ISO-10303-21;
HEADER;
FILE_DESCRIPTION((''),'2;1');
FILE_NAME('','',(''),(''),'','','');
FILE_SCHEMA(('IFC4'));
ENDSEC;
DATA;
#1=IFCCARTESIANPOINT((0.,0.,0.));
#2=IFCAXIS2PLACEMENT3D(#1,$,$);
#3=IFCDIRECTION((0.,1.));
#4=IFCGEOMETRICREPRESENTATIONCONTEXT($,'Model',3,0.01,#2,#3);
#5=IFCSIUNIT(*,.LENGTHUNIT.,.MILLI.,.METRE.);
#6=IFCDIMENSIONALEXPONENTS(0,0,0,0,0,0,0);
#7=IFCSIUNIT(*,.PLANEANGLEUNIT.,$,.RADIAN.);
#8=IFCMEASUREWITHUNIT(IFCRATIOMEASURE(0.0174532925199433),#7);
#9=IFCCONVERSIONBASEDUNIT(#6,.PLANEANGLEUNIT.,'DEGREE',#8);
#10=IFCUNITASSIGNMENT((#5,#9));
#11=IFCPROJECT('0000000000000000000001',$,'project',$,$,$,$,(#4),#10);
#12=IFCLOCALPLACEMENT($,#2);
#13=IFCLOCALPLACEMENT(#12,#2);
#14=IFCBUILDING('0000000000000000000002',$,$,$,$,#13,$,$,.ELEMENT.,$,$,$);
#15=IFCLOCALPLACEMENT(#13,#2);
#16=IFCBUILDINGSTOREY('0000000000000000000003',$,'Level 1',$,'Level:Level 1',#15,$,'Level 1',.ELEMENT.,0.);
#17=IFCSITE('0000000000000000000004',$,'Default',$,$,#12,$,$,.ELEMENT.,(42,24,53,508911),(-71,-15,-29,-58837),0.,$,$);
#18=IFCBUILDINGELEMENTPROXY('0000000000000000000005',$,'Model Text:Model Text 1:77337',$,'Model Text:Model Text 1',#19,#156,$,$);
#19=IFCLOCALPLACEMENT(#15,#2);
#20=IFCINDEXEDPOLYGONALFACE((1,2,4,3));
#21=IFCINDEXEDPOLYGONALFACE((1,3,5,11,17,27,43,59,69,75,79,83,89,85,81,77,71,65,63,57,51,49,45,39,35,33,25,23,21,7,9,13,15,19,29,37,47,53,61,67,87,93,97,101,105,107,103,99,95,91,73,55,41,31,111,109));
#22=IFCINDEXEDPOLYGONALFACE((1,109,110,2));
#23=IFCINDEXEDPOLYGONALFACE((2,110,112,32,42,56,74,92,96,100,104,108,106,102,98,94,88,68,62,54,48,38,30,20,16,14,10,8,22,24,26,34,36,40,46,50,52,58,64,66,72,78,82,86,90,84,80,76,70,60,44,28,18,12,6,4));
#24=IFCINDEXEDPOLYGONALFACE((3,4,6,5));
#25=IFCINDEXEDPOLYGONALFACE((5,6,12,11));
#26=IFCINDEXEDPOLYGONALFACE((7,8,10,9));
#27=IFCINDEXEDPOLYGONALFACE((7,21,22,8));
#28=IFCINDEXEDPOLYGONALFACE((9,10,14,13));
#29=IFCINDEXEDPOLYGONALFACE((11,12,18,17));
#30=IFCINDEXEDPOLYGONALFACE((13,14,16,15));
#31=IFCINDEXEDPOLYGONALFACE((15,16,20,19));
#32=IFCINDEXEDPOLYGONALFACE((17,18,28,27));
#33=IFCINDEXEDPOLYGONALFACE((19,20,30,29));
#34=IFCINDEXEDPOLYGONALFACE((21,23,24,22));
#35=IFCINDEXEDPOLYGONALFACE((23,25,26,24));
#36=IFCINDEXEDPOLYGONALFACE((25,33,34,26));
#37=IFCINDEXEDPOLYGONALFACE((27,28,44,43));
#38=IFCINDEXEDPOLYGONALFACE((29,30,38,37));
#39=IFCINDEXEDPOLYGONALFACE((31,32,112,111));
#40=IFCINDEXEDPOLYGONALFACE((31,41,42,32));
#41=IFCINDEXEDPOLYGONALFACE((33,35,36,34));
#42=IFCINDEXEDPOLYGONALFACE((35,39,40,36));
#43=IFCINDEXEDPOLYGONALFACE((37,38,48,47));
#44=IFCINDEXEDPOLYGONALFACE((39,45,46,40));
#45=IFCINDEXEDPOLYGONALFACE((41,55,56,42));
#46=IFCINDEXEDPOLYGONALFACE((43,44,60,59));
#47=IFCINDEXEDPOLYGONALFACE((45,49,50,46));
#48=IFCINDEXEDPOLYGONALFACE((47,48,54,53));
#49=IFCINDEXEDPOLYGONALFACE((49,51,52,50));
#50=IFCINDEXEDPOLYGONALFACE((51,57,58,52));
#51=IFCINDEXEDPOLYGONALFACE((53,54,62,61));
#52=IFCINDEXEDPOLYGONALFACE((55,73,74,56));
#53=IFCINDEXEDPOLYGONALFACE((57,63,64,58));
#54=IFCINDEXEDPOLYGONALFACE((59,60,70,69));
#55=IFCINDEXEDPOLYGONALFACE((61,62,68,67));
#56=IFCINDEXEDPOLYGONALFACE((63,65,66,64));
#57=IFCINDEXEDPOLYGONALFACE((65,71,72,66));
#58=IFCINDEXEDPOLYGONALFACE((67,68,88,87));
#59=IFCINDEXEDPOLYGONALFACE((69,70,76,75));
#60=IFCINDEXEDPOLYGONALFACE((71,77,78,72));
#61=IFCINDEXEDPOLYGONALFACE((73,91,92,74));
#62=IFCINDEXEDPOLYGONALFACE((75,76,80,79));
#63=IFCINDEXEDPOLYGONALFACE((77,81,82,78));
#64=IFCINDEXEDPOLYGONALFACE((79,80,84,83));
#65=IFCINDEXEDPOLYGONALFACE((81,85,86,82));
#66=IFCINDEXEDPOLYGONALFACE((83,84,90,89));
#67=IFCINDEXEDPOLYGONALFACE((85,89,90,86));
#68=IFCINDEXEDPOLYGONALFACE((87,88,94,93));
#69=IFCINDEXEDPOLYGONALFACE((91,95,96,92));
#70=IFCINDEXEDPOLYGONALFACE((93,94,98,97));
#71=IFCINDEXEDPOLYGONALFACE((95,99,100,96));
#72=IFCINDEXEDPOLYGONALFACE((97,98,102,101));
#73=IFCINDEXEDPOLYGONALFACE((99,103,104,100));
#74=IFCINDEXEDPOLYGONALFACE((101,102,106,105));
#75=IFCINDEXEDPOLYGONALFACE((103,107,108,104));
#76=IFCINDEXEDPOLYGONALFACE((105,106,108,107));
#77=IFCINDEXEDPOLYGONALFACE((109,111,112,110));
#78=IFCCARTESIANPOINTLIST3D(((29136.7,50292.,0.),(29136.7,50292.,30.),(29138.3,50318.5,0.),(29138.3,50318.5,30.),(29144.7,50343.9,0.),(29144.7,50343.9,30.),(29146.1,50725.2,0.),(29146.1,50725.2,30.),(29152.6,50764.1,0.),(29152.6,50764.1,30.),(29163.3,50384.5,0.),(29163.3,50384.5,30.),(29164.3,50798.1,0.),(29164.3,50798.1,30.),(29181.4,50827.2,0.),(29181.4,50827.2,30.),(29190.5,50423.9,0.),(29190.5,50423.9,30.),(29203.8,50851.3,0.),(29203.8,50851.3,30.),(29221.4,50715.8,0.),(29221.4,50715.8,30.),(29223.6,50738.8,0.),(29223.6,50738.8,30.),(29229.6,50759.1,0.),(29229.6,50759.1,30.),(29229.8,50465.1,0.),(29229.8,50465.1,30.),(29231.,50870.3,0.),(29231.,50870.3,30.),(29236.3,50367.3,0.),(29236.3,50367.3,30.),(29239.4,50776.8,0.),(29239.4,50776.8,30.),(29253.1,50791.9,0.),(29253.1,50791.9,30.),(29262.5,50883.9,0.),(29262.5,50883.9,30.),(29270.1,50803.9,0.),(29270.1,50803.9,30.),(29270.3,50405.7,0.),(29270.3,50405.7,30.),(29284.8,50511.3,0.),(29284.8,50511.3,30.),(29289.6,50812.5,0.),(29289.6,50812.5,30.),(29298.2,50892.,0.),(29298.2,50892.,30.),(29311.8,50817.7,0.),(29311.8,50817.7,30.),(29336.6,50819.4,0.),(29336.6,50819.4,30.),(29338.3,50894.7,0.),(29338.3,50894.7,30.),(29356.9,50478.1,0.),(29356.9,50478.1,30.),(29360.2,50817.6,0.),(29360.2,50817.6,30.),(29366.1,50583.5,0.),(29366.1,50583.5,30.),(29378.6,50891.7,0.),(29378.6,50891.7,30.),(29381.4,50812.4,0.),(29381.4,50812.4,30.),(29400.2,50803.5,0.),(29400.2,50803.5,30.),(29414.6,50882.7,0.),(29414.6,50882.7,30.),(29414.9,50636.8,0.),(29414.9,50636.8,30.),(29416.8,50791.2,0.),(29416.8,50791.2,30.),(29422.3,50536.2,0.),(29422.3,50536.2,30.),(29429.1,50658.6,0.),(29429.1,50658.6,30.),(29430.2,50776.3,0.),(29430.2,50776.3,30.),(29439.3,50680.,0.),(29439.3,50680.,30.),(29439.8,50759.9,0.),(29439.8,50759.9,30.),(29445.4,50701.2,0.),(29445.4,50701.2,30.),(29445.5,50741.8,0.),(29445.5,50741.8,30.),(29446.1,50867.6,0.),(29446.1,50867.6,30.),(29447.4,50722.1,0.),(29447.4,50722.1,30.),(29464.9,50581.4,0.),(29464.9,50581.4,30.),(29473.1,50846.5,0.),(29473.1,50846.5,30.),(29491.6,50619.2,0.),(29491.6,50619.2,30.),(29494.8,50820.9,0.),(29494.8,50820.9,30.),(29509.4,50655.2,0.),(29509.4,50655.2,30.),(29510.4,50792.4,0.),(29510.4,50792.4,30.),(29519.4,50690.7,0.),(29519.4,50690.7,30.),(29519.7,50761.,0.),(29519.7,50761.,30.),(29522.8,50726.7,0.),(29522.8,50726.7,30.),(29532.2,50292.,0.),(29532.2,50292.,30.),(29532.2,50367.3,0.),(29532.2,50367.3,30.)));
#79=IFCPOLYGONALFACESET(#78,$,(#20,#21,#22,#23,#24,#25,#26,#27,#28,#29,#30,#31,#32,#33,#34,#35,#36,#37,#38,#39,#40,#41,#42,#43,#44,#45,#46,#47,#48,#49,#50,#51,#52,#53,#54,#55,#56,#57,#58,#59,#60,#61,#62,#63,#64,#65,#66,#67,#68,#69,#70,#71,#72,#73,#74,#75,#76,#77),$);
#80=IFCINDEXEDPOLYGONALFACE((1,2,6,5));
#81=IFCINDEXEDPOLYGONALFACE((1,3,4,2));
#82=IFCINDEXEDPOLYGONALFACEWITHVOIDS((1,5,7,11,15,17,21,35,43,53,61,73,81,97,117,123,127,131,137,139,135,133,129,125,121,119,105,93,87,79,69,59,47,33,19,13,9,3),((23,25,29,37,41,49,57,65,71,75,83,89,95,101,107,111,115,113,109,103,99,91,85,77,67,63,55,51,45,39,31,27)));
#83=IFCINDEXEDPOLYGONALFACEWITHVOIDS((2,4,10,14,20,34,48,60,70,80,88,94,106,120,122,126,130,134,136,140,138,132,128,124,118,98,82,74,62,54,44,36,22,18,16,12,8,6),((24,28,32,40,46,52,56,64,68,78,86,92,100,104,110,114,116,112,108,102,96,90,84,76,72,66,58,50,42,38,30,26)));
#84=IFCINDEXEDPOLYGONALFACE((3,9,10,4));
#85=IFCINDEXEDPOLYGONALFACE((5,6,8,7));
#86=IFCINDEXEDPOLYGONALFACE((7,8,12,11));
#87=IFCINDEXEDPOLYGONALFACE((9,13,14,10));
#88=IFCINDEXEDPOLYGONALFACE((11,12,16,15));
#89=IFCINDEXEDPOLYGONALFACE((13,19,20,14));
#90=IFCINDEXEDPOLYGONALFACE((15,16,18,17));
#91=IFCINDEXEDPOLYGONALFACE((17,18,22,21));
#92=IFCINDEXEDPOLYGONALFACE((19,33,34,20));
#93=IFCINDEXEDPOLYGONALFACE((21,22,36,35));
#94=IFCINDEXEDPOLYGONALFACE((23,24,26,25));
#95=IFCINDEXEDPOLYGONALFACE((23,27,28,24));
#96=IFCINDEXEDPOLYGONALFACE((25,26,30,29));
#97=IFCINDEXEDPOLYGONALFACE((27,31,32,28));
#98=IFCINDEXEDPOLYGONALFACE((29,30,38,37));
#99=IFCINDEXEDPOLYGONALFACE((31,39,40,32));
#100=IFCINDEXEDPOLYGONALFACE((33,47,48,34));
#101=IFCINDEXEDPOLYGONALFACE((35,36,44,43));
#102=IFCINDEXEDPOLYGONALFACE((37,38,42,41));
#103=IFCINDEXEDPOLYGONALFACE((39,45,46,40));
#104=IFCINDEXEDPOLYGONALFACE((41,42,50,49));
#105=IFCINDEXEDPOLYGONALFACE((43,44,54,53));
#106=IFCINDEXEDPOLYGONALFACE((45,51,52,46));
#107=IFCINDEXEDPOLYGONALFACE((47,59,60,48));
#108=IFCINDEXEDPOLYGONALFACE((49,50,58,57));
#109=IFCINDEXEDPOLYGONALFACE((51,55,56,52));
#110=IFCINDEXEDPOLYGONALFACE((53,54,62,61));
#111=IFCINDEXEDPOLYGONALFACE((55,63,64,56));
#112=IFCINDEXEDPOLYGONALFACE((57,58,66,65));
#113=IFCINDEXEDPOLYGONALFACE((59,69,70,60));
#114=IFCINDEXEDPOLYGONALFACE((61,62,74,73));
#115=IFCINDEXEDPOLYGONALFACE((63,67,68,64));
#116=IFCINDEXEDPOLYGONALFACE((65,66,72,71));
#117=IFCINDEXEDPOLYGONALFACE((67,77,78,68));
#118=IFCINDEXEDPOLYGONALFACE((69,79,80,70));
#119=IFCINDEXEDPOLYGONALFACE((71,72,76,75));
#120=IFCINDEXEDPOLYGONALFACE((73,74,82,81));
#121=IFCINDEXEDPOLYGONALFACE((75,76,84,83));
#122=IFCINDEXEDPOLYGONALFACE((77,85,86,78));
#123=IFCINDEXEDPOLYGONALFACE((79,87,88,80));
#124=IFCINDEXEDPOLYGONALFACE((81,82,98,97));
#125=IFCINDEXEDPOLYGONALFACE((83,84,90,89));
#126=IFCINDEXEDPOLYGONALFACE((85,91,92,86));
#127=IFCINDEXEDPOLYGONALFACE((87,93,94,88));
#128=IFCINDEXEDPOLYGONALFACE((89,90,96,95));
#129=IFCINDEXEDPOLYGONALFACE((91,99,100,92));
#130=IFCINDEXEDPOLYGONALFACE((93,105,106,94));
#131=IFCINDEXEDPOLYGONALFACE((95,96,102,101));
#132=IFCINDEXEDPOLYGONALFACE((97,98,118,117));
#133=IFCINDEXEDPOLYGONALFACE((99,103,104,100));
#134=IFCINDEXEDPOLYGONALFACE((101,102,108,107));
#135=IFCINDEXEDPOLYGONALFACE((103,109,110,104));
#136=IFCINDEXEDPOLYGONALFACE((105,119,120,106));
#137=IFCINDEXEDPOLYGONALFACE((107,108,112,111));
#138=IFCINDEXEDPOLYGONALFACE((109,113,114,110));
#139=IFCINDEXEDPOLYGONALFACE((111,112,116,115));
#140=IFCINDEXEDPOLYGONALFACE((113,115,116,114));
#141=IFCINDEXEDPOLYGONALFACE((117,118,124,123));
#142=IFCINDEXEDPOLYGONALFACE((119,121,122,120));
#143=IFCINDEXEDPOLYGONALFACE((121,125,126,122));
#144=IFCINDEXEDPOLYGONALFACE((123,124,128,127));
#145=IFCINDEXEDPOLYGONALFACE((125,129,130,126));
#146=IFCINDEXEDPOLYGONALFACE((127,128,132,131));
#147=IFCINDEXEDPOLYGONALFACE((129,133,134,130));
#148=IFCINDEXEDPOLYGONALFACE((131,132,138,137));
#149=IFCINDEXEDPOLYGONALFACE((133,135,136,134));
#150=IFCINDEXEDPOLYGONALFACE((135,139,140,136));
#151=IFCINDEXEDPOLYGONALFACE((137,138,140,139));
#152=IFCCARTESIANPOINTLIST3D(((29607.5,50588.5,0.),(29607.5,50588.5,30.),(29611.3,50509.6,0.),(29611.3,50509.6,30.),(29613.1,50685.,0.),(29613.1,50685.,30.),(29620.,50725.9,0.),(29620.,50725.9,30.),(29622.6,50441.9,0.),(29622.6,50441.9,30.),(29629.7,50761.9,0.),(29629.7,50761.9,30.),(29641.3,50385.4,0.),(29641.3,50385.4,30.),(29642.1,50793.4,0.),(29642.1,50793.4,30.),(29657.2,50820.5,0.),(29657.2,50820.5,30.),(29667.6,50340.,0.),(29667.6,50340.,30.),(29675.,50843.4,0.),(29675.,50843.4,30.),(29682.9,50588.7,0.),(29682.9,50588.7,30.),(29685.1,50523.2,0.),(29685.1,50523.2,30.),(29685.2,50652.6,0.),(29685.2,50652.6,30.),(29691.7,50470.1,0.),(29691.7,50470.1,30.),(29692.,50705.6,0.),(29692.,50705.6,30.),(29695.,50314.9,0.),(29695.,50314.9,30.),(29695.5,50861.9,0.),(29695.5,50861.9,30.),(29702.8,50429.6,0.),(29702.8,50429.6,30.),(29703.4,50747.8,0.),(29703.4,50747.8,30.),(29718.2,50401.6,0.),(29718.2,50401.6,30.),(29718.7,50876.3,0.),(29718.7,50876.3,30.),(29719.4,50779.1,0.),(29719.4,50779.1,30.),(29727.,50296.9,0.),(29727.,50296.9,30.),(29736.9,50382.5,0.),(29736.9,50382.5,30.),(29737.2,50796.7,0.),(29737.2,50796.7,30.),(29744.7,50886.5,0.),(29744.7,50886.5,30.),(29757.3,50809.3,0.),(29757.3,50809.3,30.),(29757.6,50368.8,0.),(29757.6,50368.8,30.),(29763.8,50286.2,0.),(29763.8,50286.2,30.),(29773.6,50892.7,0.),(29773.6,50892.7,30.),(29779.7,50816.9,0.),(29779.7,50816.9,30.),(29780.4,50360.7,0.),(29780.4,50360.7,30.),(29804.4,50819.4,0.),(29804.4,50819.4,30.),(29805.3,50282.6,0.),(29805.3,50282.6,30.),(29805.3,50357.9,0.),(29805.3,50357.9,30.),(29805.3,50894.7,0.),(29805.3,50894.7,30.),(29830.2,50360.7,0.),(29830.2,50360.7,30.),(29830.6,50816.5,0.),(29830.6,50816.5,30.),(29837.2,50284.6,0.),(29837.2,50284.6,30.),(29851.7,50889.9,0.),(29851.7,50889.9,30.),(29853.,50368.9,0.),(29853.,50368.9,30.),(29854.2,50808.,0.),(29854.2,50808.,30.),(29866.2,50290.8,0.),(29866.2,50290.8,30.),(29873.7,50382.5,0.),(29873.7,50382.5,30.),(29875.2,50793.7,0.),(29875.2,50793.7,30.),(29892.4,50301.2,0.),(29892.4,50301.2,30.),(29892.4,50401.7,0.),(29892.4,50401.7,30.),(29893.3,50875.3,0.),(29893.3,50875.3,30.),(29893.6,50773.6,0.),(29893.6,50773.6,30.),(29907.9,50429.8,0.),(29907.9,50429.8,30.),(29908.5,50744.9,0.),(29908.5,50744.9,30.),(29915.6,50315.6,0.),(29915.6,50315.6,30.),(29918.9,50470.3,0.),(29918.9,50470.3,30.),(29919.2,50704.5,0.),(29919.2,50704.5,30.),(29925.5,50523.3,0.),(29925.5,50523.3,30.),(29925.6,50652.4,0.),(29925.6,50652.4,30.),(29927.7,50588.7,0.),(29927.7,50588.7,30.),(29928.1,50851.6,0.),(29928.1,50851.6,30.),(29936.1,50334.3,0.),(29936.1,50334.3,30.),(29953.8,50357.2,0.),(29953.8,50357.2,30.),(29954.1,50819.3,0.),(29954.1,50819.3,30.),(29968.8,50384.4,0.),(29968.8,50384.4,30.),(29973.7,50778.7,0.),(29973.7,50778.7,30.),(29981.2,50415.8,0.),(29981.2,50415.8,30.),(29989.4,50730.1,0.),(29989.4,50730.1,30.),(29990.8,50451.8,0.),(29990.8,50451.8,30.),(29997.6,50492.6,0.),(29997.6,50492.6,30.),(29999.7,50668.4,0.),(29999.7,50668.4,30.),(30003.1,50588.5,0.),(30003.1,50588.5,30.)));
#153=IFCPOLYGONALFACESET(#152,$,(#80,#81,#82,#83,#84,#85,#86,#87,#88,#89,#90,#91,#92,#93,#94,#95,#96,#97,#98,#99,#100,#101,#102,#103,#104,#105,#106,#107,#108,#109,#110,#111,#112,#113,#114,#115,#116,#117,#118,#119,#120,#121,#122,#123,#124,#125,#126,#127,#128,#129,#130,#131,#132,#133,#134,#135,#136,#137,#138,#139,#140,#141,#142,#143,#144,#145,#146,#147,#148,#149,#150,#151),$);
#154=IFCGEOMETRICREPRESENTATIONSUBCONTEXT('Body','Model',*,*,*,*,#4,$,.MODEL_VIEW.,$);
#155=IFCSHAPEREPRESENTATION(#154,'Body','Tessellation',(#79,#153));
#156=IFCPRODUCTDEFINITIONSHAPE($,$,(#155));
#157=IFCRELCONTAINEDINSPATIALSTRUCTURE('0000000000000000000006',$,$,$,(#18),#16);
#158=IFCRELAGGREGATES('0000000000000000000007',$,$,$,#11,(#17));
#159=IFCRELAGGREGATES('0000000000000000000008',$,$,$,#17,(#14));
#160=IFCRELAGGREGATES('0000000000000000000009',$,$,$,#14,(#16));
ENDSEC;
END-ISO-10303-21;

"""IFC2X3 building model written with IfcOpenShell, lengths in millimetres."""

from ifc_helpers import new_model, entity, si_unit, converted_unit, direction, frame, origin, place, context, subcontext, project, spatial, polyline, outline, extrude, element, save


model = new_model("IFC2X3")

# Units and contexts
model_context = context("Model", 3, precision=0.01, world=origin(), true_north=direction((0.0, 1.0)))
body_context = subcontext(model_context, "Body", "Model", "MODEL_VIEW")
ifc_project = project(units=[si_unit("LENGTHUNIT", "METRE", prefix="MILLI"), converted_unit("PLANEANGLEUNIT", "DEGREE", entity("IfcRatioMeasure", 0.0174532925199433), si_unit("PLANEANGLEUNIT", "RADIAN"), dimensions=[0, 0, 0, 0, 0, 0, 0])], contexts=[model_context])

# Site, building, storey
site_placement = place(None, origin())
site = spatial("IfcSite", under=ifc_project, at=site_placement, Name="Default", CompositionType="ELEMENT", RefLatitude=(42, 24, 53, 508911), RefLongitude=(-71, -15, -29, -58837), RefElevation=0.0)
building_placement = place(site_placement, origin())
building = spatial("IfcBuilding", under=site, at=building_placement, CompositionType="ELEMENT")
storey_placement = place(building_placement, origin())
storey = spatial("IfcBuildingStorey", under=building, at=storey_placement, Name="Level 1", ObjectType="Level:Level 1", LongName="Level 1", CompositionType="ELEMENT", Elevation=0.0)

# Building element proxy
proxy_1_placement = place(storey_placement, origin())
element("IfcBuildingElementProxy", 1, at=proxy_1_placement, inside=storey, Name="Model Text:Model Text 1:77337", ObjectType="Model Text:Model Text 1", context=body_context, shape_type="SweptSolid", body=[
    extrude(outline(polyline([(-190.2, -317.5), (-190.2, -392.8), (205.4, -392.8), (203.7, -366.3), (197.3, -340.9), (178.7, -300.3), (151.5, -260.9), (112.2, -219.7), (57.2, -173.6), (-24.1, -101.3), (-72.9, -48.0), (-87.1, -26.3), (-97.3, -4.8), (-103.4, 16.4), (-105.4, 37.3), (-103.5, 57.0), (-97.7, 75.0), (-88.2, 91.5), (-74.7, 106.4), (-58.2, 118.7), (-39.4, 127.5), (-18.2, 132.8), (5.4, 134.6), (30.2, 132.9), (52.4, 127.7), (72.0, 119.1), (88.9, 107.1), (102.6, 92.0), (112.5, 74.3), (118.5, 54.0), (120.6, 31.0), (196.0, 40.4), (189.5, 79.3), (177.7, 113.3), (160.6, 142.4), (138.2, 166.5), (111.0, 185.5), (79.5, 199.1), (43.8, 207.2), (3.8, 209.9), (-36.6, 206.9), (-72.5, 197.9), (-104.0, 182.8), (-131.1, 161.7), (-152.8, 136.1), (-168.3, 107.6), (-177.6, 76.2), (-180.8, 41.9), (-177.4, 5.8), (-167.4, -29.6), (-149.5, -65.6), (-122.8, -103.4), (-80.3, -148.6), (-14.9, -206.7), (71.8, -279.1), (105.8, -317.5), (-190.2, -317.5)])), frame((29342.0, 50684.8, 0.0), z_axis=(0.0, 0.0, -1.0), x_axis=(-1.0, 0.0, 0.0)), (0.0, 0.0, -1.0), 30.0),
    extrude(outline(polyline([(-10.6, -198.7), (68.3, -198.7), (136.5, -190.7), (193.9, -174.7), (240.5, -150.6), (266.9, -124.4), (286.3, -93.2), (298.8, -57.0), (304.3, -15.7), (303.8, 16.2), (299.0, 45.5), (289.9, 72.1), (276.6, 96.0), (258.9, 117.3), (236.9, 136.2), (210.4, 152.5), (179.6, 166.3), (144.1, 177.6), (103.7, 186.3), (8.2, 196.4), (-71.8, 196.7), (-134.0, 189.4), (-183.3, 176.1), (-224.7, 158.4), (-258.2, 133.9), (-283.5, 100.3), (-300.1, 59.5), (-307.1, 13.4), (-306.6, -18.4), (-301.8, -47.5), (-292.8, -74.0), (-279.6, -97.9), (-262.0, -119.2), (-240.0, -138.1), (-213.6, -154.5), (-182.8, -168.4), (-147.3, -179.8), (-106.7, -188.6), (-10.6, -198.7)]), holes=[polyline([(-7.2, -123.5), (-71.0, -118.2), (-123.6, -108.8), (-165.2, -95.4), (-195.7, -78.0), (-212.4, -59.4), (-224.1, -38.7), (-230.6, -15.9), (-231.9, 8.9), (-227.8, 35.0), (-218.1, 58.1), (-202.8, 78.4), (-182.0, 95.8), (-152.6, 109.4), (-111.7, 118.1), (-59.4, 122.0), (4.4, 121.1), (69.6, 115.8), (122.2, 106.7), (162.2, 93.7), (189.5, 77.0), (207.7, 57.4), (220.4, 36.0), (227.5, 12.8), (229.1, -12.1), (225.2, -36.8), (215.9, -59.2), (201.3, -79.3), (181.4, -97.1), (152.6, -111.2), (111.6, -120.3), (58.3, -124.4), (-7.2, -123.5)])]), frame((29806.6, 50587.3, 0.0), z_axis=(0.0, 0.0, 1.0), x_axis=(0.047515, -0.998871, 0.0)), (0.0, 0.0, 1.0), 30.0),
])

save(model, "model.ifc")
